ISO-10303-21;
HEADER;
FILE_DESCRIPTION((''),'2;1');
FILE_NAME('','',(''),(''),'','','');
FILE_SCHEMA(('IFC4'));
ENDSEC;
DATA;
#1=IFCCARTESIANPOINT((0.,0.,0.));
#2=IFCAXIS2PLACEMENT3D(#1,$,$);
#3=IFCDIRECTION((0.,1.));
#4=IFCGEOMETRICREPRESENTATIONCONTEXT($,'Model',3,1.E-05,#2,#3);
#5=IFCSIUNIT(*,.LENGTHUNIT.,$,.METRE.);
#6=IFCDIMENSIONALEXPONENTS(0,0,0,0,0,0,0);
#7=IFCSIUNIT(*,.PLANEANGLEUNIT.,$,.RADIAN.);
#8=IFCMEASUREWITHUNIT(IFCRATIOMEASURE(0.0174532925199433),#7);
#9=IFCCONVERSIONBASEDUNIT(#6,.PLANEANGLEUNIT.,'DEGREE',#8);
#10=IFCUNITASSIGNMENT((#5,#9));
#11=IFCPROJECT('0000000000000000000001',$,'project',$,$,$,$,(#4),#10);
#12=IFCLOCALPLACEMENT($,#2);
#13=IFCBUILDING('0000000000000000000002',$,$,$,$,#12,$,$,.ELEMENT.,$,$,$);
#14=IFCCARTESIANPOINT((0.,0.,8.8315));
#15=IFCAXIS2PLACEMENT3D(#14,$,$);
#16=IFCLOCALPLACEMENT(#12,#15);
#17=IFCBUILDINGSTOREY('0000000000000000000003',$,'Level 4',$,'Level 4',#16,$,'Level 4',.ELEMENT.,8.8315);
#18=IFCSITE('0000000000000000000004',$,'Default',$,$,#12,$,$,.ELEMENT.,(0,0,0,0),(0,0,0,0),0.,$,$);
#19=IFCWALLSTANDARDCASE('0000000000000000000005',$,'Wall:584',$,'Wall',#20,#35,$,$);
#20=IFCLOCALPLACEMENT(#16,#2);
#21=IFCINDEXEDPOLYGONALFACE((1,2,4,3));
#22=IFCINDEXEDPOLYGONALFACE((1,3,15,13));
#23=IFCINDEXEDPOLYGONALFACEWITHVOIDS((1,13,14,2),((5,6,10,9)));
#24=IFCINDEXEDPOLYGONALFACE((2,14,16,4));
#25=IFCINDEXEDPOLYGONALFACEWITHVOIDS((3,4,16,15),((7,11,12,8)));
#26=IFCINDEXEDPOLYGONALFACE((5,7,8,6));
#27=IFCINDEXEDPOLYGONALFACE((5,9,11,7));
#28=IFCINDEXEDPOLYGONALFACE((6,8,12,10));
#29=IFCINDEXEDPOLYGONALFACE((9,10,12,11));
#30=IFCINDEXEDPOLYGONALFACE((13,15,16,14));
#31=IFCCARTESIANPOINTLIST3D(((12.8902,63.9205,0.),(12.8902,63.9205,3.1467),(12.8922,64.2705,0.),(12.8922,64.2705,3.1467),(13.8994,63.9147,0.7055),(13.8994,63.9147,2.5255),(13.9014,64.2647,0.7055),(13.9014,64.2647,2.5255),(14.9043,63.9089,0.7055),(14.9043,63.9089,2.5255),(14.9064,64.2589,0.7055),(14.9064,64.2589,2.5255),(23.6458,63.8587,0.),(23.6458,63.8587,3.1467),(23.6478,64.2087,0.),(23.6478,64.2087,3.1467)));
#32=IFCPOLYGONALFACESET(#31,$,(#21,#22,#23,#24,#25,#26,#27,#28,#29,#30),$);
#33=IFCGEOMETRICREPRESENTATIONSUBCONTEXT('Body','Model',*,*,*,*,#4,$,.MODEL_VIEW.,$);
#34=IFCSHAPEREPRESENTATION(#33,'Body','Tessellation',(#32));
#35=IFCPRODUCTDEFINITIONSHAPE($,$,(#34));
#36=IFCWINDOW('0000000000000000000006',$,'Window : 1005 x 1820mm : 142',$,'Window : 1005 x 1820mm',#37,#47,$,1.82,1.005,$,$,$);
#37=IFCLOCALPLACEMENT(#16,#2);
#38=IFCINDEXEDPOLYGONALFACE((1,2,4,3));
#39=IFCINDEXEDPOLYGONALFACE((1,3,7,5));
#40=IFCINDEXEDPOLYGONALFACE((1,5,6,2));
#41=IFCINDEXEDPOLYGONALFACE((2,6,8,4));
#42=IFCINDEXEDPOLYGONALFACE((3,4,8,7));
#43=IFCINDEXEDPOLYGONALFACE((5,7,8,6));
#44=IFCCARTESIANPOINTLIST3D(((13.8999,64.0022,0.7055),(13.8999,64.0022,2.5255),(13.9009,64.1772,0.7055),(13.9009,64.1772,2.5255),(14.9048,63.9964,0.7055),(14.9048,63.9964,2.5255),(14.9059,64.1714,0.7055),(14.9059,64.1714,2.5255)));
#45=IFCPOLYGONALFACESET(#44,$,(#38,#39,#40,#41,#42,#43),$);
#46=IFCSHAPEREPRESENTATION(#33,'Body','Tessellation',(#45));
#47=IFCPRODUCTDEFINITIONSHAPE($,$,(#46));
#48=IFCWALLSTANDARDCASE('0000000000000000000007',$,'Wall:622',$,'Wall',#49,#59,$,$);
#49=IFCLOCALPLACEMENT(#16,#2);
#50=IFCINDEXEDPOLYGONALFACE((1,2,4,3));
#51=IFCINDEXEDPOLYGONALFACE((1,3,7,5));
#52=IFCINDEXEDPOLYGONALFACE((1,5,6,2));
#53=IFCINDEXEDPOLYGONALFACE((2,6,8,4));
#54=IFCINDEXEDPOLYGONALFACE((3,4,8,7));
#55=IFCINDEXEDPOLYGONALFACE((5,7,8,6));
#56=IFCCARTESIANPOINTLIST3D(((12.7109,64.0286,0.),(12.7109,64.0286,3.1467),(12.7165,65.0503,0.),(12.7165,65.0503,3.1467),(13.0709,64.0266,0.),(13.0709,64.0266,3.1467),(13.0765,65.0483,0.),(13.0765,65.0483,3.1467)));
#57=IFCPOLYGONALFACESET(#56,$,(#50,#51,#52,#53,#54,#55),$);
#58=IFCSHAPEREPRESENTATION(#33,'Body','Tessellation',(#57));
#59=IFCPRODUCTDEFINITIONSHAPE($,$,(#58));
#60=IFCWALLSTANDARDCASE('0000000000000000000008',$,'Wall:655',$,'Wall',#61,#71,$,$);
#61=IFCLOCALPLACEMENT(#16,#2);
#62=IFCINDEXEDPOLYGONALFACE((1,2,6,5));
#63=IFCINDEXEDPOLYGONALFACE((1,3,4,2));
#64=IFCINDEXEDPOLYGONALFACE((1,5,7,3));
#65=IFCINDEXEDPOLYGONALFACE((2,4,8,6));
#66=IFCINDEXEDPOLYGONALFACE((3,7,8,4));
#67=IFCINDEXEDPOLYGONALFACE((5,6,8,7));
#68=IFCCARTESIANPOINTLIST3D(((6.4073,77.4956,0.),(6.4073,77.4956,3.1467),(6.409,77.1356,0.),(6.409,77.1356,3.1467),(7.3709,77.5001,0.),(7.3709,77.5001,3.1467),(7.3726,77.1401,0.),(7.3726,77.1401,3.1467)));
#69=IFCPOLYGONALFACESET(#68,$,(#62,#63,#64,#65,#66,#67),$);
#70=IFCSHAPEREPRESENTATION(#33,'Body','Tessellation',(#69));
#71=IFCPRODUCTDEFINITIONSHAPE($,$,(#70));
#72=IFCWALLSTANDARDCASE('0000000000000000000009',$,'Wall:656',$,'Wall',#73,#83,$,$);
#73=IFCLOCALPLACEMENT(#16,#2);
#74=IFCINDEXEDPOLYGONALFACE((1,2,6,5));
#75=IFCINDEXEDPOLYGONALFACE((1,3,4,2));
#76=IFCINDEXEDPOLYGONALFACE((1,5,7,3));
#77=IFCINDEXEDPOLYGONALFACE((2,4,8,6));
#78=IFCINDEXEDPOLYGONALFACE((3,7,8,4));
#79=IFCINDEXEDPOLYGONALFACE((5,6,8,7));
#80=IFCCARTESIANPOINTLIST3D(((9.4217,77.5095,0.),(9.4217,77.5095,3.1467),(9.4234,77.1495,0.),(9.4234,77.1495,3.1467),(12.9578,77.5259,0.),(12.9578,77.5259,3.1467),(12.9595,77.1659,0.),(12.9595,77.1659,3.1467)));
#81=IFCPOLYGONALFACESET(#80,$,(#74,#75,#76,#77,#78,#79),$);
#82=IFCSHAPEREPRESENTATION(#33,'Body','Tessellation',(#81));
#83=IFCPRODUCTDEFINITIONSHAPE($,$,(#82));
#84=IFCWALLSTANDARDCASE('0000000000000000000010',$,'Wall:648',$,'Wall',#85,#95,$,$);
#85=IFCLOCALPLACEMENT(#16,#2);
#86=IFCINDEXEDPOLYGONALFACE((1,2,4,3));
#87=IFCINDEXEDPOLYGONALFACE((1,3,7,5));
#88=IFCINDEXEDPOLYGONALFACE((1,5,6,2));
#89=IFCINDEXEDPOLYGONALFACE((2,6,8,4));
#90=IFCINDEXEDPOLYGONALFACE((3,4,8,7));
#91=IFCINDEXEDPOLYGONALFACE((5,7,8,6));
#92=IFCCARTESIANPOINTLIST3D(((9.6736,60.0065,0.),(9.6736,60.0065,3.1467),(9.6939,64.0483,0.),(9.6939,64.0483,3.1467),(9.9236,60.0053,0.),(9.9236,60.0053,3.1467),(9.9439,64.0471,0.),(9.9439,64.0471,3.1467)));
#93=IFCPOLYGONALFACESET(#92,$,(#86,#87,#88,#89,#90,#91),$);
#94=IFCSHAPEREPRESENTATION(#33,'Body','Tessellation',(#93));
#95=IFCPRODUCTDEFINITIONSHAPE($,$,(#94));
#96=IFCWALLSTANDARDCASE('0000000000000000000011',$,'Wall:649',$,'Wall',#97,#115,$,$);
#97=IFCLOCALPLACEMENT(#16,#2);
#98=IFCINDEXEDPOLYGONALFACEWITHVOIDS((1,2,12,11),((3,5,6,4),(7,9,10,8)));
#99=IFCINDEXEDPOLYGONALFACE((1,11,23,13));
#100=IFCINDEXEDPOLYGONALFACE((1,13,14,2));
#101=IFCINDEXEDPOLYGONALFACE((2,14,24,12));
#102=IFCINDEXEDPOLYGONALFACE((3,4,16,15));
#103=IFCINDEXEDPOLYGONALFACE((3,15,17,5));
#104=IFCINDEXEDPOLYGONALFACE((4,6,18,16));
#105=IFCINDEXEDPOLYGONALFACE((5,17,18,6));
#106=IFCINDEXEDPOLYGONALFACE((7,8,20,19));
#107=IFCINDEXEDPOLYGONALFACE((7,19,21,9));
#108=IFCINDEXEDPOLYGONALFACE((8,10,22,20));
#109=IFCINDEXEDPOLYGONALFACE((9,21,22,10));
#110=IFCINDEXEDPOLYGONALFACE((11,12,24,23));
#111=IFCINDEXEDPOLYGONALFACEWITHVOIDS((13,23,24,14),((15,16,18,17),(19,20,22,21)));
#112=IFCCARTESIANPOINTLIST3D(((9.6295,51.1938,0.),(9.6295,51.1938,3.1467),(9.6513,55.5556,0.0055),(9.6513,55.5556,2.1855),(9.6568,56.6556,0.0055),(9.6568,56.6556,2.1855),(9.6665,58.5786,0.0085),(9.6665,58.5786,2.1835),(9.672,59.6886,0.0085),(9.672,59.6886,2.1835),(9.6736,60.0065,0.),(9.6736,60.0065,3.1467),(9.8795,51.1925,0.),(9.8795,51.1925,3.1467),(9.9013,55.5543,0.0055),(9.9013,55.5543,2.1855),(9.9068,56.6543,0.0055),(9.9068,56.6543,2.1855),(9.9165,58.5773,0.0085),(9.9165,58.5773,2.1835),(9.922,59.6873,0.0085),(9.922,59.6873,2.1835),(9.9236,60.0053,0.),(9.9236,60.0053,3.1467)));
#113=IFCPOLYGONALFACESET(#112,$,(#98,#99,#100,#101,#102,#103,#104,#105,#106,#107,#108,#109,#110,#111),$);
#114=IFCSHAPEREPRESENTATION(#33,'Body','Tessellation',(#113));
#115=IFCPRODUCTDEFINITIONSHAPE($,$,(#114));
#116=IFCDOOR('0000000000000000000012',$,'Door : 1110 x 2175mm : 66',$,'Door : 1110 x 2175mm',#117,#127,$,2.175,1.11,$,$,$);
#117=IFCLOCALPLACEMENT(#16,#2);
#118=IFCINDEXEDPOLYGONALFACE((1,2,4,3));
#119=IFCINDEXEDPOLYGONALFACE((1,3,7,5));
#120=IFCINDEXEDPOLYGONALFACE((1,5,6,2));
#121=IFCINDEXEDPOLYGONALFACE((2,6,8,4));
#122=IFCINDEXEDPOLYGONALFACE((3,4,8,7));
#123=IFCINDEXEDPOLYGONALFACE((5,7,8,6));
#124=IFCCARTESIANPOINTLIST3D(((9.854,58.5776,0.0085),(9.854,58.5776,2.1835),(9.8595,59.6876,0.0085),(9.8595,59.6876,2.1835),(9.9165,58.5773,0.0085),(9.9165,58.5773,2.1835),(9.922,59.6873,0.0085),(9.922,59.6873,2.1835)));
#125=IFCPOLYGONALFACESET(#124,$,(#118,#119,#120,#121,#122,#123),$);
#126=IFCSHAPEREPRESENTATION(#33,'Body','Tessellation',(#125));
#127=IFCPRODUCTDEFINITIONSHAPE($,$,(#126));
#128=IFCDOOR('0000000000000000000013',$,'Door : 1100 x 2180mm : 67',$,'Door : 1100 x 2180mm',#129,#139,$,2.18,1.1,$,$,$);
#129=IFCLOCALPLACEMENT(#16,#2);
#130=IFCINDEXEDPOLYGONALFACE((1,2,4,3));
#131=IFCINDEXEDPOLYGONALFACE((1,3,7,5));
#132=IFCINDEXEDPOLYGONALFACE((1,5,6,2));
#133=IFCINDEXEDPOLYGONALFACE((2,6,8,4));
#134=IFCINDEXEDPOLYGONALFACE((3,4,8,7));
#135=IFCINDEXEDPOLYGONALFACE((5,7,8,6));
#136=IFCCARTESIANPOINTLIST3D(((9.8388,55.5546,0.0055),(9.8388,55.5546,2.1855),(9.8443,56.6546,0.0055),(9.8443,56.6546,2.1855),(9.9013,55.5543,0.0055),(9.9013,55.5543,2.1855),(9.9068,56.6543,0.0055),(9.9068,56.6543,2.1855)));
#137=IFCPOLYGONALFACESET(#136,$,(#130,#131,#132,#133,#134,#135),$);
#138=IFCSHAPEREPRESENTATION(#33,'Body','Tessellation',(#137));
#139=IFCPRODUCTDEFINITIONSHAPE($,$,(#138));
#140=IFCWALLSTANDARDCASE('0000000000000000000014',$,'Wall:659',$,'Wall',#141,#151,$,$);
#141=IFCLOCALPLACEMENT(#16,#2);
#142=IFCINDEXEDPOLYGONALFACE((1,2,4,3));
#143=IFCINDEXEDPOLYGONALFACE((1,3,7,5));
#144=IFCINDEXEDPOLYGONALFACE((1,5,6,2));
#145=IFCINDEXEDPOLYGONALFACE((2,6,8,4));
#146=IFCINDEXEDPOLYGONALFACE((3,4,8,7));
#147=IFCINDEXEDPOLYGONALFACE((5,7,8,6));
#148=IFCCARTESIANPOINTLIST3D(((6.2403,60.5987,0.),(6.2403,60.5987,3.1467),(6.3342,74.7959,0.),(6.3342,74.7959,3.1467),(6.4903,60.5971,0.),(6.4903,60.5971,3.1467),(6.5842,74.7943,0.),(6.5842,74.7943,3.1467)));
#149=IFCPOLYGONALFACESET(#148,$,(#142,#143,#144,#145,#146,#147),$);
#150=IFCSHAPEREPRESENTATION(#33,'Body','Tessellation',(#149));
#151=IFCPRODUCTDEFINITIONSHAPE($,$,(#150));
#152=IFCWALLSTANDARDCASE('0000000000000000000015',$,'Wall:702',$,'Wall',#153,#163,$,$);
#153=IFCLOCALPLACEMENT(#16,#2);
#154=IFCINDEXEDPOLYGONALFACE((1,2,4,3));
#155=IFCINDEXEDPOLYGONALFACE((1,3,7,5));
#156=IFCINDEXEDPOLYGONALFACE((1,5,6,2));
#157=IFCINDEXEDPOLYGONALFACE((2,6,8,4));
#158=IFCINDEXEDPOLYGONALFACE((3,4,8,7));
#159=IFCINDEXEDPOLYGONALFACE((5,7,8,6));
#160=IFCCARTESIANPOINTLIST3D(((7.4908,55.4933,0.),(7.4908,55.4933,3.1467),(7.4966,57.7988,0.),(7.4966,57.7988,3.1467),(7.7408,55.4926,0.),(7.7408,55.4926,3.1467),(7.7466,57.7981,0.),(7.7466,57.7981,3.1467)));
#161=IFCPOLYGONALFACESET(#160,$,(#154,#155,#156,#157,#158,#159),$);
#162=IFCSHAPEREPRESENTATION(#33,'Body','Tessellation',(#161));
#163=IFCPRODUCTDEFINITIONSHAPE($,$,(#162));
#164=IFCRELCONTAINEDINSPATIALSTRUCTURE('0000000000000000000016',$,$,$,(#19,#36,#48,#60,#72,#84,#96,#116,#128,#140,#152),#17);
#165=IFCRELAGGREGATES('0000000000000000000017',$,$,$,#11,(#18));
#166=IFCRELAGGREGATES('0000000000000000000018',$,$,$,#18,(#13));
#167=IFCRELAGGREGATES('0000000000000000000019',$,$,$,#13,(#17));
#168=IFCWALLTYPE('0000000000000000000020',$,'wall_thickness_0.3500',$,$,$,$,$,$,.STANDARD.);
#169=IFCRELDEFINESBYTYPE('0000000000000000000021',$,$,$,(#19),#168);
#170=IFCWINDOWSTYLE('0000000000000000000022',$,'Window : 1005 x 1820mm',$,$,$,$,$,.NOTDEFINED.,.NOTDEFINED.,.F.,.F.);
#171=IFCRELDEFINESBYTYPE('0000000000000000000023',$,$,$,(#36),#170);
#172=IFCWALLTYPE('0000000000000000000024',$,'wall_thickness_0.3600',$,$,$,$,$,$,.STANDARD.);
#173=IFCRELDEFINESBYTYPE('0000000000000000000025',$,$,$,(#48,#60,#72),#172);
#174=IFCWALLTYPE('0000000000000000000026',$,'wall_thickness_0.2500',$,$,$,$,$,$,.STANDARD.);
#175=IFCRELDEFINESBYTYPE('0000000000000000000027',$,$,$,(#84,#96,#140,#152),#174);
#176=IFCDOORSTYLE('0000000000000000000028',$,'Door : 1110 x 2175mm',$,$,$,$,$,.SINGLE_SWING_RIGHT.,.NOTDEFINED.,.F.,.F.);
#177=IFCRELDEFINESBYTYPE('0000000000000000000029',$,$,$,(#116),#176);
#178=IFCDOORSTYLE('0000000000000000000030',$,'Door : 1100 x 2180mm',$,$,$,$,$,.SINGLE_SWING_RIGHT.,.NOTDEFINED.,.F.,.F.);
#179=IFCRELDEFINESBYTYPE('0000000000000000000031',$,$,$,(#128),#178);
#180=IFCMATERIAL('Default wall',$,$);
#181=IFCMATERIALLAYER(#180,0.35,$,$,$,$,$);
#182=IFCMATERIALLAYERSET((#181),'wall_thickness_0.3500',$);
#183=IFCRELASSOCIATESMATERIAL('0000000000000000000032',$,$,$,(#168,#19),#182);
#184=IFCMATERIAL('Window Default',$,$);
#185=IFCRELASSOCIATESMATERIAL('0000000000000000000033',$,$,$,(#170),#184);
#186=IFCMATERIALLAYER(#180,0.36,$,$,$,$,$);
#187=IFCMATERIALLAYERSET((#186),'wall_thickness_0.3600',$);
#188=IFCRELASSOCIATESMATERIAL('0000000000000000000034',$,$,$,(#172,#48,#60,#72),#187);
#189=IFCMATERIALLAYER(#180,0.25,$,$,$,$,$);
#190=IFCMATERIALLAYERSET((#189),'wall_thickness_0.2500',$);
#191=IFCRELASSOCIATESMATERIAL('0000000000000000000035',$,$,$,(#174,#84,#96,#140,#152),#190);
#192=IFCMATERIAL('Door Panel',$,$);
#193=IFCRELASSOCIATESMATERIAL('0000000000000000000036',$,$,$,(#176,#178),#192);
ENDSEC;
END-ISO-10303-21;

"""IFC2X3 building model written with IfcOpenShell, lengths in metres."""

from ifc_helpers import new_model, entity, si_unit, converted_unit, direction, frame, frame_2d, origin, origin_2d_with_axis, place, context, subcontext, project, spatial, polyline, rectangle, outline, extrude, source, transform, mapped, material, layer, layer_set, layer_usage, type_object, type_shapes, element, fill, save


model = new_model("IFC2X3")

# Units and contexts
model_context = context("Model", 3, precision=1e-05, world=origin(), true_north=direction((0.0, 1.0)))
body_context = subcontext(model_context, "Body", "Model", "MODEL_VIEW")
ifc_project = project(units=[si_unit("LENGTHUNIT", "METRE"), converted_unit("PLANEANGLEUNIT", "DEGREE", entity("IfcRatioMeasure", 0.0174532925199433), si_unit("PLANEANGLEUNIT", "RADIAN"), dimensions=[0, 0, 0, 0, 0, 0, 0])], contexts=[model_context])

# Site, building, storey
placement_1 = place(None, origin())
site = spatial("IfcSite", under=ifc_project, at=placement_1, Name="Default", CompositionType="ELEMENT", RefLatitude=(0, 0, 0, 0), RefLongitude=(0, 0, 0, 0), RefElevation=0.0)
building = spatial("IfcBuilding", under=site, at=placement_1, CompositionType="ELEMENT")
storey_placement = place(placement_1, frame((0.0, 0.0, 8.8315)))
storey = spatial("IfcBuildingStorey", under=building, at=storey_placement, Name="Level 4", ObjectType="Level 4", LongName="Level 4", CompositionType="ELEMENT", Elevation=8.8315)

# Wall, opening, window
ifc_material_1 = material(Name="Default wall")
ifc_layer_1 = layer(ifc_material_1, 0.35)
ifc_layer_set_1 = layer_set([ifc_layer_1], Name="wall_thickness_0.3500")
ifc_layer_usage_1 = layer_usage(ifc_layer_set_1, "AXIS2", "POSITIVE", -0.175)
wall_type_1 = type_object("IfcWallType", Name="wall_thickness_0.3500", PredefinedType="STANDARD", material=ifc_layer_set_1)
wall_1_placement = place(storey_placement, frame((12.8912, 64.0955, 0.0), z_axis=(0.0, 0.0, 1.0), x_axis=(0.999983, -0.005748, 0.0)))
wall_1 = element("IfcWallStandardCase", 1, at=wall_1_placement, inside=storey, type_object=wall_type_1, material=ifc_layer_usage_1, Name="Wall:584", ObjectType="Wall", context=body_context, shape_type="SweptSolid", body=[
    extrude(outline(polyline([(10.7557, -0.175), (10.7557, 0.175), (0.0, 0.175), (0.0, -0.175), (10.7557, -0.175)])), origin(), (0.0, 0.0, 1.0), 3.1467),
])
opening_1_placement = place(wall_1_placement, frame((1.0091, -0.175, 0.7055)))
opening_1 = element("IfcOpeningElement", 2, at=opening_1_placement, cuts=wall_1, ObjectType="Opening", context=body_context, shape_type="SweptSolid", body=[
    extrude(rectangle(XDim=1.005, YDim=1.82, at=frame_2d((0.91, 0.5025), x_axis=(0.0, 1.0))), frame((0.0, 0.0, 0.0), z_axis=(0.0, 1.0, 0.0), x_axis=(0.0, 0.0, 1.0)), (0.0, 0.0, 1.0), 0.35),
])
ifc_material_2 = material(Name="Window Default")
window_style_1 = type_object("IfcWindowStyle", Name="Window : 1005 x 1820mm", ConstructionType="NOTDEFINED", OperationType="NOTDEFINED", ParameterTakesPrecedence=False, Sizeable=False, material=ifc_material_2)
shared_shape_1 = source(origin(), body_context, "Body", "SweptSolid", [
    extrude(rectangle(XDim=0.175, YDim=1.005, at=origin_2d_with_axis()), frame((0.5025, 0.175, 0.0), z_axis=(0.0, 0.0, 1.0), x_axis=(0.0, 1.0, 0.0)), (0.0, 0.0, 1.0), 1.82),
])
type_shapes(window_style_1, [shared_shape_1])
window_1_placement = place(opening_1_placement, origin())
window_1 = element("IfcWindow", 3, at=window_1_placement, inside=storey, type_object=window_style_1, Name="Window : 1005 x 1820mm : 142", ObjectType="Window : 1005 x 1820mm", OverallHeight=1.82, OverallWidth=1.005, context=body_context, shape_type="MappedRepresentation", body=[
    mapped(shared_shape_1, transform((0.0, 0.0, 0.0), scale=1.0)),
])
fill(opening_1, window_1)

# Walls
ifc_layer_2 = layer(ifc_material_1, 0.36)
ifc_layer_set_2 = layer_set([ifc_layer_2], Name="wall_thickness_0.3600")
ifc_layer_usage_2 = layer_usage(ifc_layer_set_2, "AXIS2", "POSITIVE", -0.18)
wall_type_2 = type_object("IfcWallType", Name="wall_thickness_0.3600", PredefinedType="STANDARD", material=ifc_layer_set_2)
wall_2_placement = place(storey_placement, frame((12.8965, 65.0493, 0.0), z_axis=(0.0, 0.0, 1.0), x_axis=(-0.005466, -0.999985, 0.0)))
element("IfcWallStandardCase", 4, at=wall_2_placement, inside=storey, type_object=wall_type_2, material=ifc_layer_usage_2, Name="Wall:622", ObjectType="Wall", context=body_context, shape_type="SweptSolid", body=[
    extrude(outline(polyline([(1.0217, -0.18), (1.0217, 0.18), (0.0, 0.18), (0.0, -0.18), (1.0217, -0.18)])), origin(), (0.0, 0.0, 1.0), 3.1467),
])
wall_3_placement = place(storey_placement, frame((6.4082, 77.3156, 0.0), z_axis=(0.0, 0.0, 1.0), x_axis=(0.999989, 0.004624, 0.0)))
element("IfcWallStandardCase", 5, at=wall_3_placement, inside=storey, type_object=wall_type_2, material=ifc_layer_usage_2, Name="Wall:655", ObjectType="Wall", context=body_context, shape_type="SweptSolid", body=[
    extrude(outline(polyline([(0.9636, -0.18), (0.9636, 0.18), (0.0, 0.18), (0.0, -0.18), (0.9636, -0.18)])), origin(), (0.0, 0.0, 1.0), 3.1467),
])
wall_4_placement = place(storey_placement, frame((9.4225, 77.3295, 0.0), z_axis=(0.0, 0.0, 1.0), x_axis=(0.999989, 0.004626, 0.0)))
element("IfcWallStandardCase", 6, at=wall_4_placement, inside=storey, type_object=wall_type_2, material=ifc_layer_usage_2, Name="Wall:656", ObjectType="Wall", context=body_context, shape_type="SweptSolid", body=[
    extrude(outline(polyline([(3.5362, -0.18), (3.5362, 0.18), (0.0, 0.18), (0.0, -0.18), (3.5362, -0.18)])), origin(), (0.0, 0.0, 1.0), 3.1467),
])
ifc_layer_3 = layer(ifc_material_1, 0.25)
ifc_layer_set_3 = layer_set([ifc_layer_3], Name="wall_thickness_0.2500")
ifc_layer_usage_3 = layer_usage(ifc_layer_set_3, "AXIS2", "POSITIVE", -0.125)
wall_type_3 = type_object("IfcWallType", Name="wall_thickness_0.2500", PredefinedType="STANDARD", material=ifc_layer_set_3)
wall_5_placement = place(storey_placement, frame((9.8189, 64.0477, 0.0), z_axis=(0.0, 0.0, 1.0), x_axis=(-0.005007, -0.999987, 0.0)))
element("IfcWallStandardCase", 7, at=wall_5_placement, inside=storey, type_object=wall_type_3, material=ifc_layer_usage_3, Name="Wall:648", ObjectType="Wall", context=body_context, shape_type="SweptSolid", body=[
    extrude(outline(polyline([(4.0419, -0.125), (4.0419, 0.125), (0.0, 0.125), (0.0, -0.125), (4.0419, -0.125)])), origin(), (0.0, 0.0, 1.0), 3.1467),
])

# Wall, openings, doors
wall_6_placement = place(storey_placement, frame((9.7986, 60.0059, 0.0), z_axis=(0.0, 0.0, 1.0), x_axis=(-0.005007, -0.999987, 0.0)))
wall_6 = element("IfcWallStandardCase", 8, at=wall_6_placement, inside=storey, type_object=wall_type_3, material=ifc_layer_usage_3, Name="Wall:649", ObjectType="Wall", context=body_context, shape_type="SweptSolid", body=[
    extrude(outline(polyline([(8.8129, -0.125), (8.8129, 0.125), (0.0, 0.125), (0.0, -0.125), (8.8129, -0.125)])), origin(), (0.0, 0.0, 1.0), 3.1467),
])
opening_2_placement = place(wall_6_placement, frame((0.318, -0.125, 0.0085)))
opening_2 = element("IfcOpeningElement", 9, at=opening_2_placement, cuts=wall_6, ObjectType="Opening", context=body_context, shape_type="SweptSolid", body=[
    extrude(rectangle(XDim=1.11, YDim=2.175, at=frame_2d((1.0875, 0.555), x_axis=(0.0, 1.0))), frame((0.0, 0.0, 0.0), z_axis=(0.0, 1.0, 0.0), x_axis=(0.0, 0.0, 1.0)), (0.0, 0.0, 1.0), 0.25),
])
opening_3_placement = place(wall_6_placement, frame((3.351, -0.125, 0.0055)))
opening_3 = element("IfcOpeningElement", 10, at=opening_3_placement, cuts=wall_6, ObjectType="Opening", context=body_context, shape_type="SweptSolid", body=[
    extrude(rectangle(XDim=1.1, YDim=2.18, at=frame_2d((1.09, 0.55), x_axis=(0.0, 1.0))), frame((0.0, 0.0, 0.0), z_axis=(0.0, 1.0, 0.0), x_axis=(0.0, 0.0, 1.0)), (0.0, 0.0, 1.0), 0.25),
])
ifc_material_3 = material(Name="Door Panel")
door_style_1 = type_object("IfcDoorStyle", Name="Door : 1110 x 2175mm", ConstructionType="NOTDEFINED", OperationType="SINGLE_SWING_RIGHT", ParameterTakesPrecedence=False, Sizeable=False, material=ifc_material_3)
shared_shape_2 = source(origin(), body_context, "Body", "SweptSolid", [
    extrude(rectangle(XDim=0.0625, YDim=1.11, at=origin_2d_with_axis()), frame((0.555, 0.2188, 0.0), z_axis=(0.0, 0.0, 1.0), x_axis=(0.0, 1.0, 0.0)), (0.0, 0.0, 1.0), 2.175),
])
type_shapes(door_style_1, [shared_shape_2])
door_1_placement = place(opening_2_placement, origin())
door_1 = element("IfcDoor", 11, at=door_1_placement, inside=storey, type_object=door_style_1, Name="Door : 1110 x 2175mm : 66", ObjectType="Door : 1110 x 2175mm", OverallHeight=2.175, OverallWidth=1.11, context=body_context, shape_type="MappedRepresentation", body=[
    mapped(shared_shape_2, transform((0.0, 0.0, 0.0), scale=1.0)),
])
fill(opening_2, door_1)
door_style_2 = type_object("IfcDoorStyle", Name="Door : 1100 x 2180mm", ConstructionType="NOTDEFINED", OperationType="SINGLE_SWING_RIGHT", ParameterTakesPrecedence=False, Sizeable=False, material=ifc_material_3)
shared_shape_3 = source(origin(), body_context, "Body", "SweptSolid", [
    extrude(rectangle(XDim=0.0625, YDim=1.1, at=origin_2d_with_axis()), frame((0.55, 0.2188, 0.0), z_axis=(0.0, 0.0, 1.0), x_axis=(0.0, 1.0, 0.0)), (0.0, 0.0, 1.0), 2.18),
])
type_shapes(door_style_2, [shared_shape_3])
door_2_placement = place(opening_3_placement, origin())
door_2 = element("IfcDoor", 12, at=door_2_placement, inside=storey, type_object=door_style_2, Name="Door : 1100 x 2180mm : 67", ObjectType="Door : 1100 x 2180mm", OverallHeight=2.18, OverallWidth=1.1, context=body_context, shape_type="MappedRepresentation", body=[
    mapped(shared_shape_3, transform((0.0, 0.0, 0.0), scale=1.0)),
])
fill(opening_3, door_2)

# Walls
wall_7_placement = place(storey_placement, frame((6.4592, 74.7951, 0.0), z_axis=(0.0, 0.0, 1.0), x_axis=(-0.006612, -0.999978, 0.0)))
element("IfcWallStandardCase", 13, at=wall_7_placement, inside=storey, type_object=wall_type_3, material=ifc_layer_usage_3, Name="Wall:659", ObjectType="Wall", context=body_context, shape_type="SweptSolid", body=[
    extrude(outline(polyline([(14.1975, -0.125), (14.1975, 0.125), (0.0, 0.125), (0.0, -0.125), (14.1975, -0.125)])), origin(), (0.0, 0.0, 1.0), 3.1467),
])
wall_8_placement = place(storey_placement, frame((7.6216, 57.7984, 0.0), z_axis=(0.0, 0.0, 1.0), x_axis=(-0.002517, -0.999997, 0.0)))
element("IfcWallStandardCase", 14, at=wall_8_placement, inside=storey, type_object=wall_type_3, material=ifc_layer_usage_3, Name="Wall:702", ObjectType="Wall", context=body_context, shape_type="SweptSolid", body=[
    extrude(outline(polyline([(2.3055, -0.125), (2.3055, 0.125), (0.0, 0.125), (0.0, -0.125), (2.3055, -0.125)])), origin(), (0.0, 0.0, 1.0), 3.1467),
])

save(model, "model.ifc")
